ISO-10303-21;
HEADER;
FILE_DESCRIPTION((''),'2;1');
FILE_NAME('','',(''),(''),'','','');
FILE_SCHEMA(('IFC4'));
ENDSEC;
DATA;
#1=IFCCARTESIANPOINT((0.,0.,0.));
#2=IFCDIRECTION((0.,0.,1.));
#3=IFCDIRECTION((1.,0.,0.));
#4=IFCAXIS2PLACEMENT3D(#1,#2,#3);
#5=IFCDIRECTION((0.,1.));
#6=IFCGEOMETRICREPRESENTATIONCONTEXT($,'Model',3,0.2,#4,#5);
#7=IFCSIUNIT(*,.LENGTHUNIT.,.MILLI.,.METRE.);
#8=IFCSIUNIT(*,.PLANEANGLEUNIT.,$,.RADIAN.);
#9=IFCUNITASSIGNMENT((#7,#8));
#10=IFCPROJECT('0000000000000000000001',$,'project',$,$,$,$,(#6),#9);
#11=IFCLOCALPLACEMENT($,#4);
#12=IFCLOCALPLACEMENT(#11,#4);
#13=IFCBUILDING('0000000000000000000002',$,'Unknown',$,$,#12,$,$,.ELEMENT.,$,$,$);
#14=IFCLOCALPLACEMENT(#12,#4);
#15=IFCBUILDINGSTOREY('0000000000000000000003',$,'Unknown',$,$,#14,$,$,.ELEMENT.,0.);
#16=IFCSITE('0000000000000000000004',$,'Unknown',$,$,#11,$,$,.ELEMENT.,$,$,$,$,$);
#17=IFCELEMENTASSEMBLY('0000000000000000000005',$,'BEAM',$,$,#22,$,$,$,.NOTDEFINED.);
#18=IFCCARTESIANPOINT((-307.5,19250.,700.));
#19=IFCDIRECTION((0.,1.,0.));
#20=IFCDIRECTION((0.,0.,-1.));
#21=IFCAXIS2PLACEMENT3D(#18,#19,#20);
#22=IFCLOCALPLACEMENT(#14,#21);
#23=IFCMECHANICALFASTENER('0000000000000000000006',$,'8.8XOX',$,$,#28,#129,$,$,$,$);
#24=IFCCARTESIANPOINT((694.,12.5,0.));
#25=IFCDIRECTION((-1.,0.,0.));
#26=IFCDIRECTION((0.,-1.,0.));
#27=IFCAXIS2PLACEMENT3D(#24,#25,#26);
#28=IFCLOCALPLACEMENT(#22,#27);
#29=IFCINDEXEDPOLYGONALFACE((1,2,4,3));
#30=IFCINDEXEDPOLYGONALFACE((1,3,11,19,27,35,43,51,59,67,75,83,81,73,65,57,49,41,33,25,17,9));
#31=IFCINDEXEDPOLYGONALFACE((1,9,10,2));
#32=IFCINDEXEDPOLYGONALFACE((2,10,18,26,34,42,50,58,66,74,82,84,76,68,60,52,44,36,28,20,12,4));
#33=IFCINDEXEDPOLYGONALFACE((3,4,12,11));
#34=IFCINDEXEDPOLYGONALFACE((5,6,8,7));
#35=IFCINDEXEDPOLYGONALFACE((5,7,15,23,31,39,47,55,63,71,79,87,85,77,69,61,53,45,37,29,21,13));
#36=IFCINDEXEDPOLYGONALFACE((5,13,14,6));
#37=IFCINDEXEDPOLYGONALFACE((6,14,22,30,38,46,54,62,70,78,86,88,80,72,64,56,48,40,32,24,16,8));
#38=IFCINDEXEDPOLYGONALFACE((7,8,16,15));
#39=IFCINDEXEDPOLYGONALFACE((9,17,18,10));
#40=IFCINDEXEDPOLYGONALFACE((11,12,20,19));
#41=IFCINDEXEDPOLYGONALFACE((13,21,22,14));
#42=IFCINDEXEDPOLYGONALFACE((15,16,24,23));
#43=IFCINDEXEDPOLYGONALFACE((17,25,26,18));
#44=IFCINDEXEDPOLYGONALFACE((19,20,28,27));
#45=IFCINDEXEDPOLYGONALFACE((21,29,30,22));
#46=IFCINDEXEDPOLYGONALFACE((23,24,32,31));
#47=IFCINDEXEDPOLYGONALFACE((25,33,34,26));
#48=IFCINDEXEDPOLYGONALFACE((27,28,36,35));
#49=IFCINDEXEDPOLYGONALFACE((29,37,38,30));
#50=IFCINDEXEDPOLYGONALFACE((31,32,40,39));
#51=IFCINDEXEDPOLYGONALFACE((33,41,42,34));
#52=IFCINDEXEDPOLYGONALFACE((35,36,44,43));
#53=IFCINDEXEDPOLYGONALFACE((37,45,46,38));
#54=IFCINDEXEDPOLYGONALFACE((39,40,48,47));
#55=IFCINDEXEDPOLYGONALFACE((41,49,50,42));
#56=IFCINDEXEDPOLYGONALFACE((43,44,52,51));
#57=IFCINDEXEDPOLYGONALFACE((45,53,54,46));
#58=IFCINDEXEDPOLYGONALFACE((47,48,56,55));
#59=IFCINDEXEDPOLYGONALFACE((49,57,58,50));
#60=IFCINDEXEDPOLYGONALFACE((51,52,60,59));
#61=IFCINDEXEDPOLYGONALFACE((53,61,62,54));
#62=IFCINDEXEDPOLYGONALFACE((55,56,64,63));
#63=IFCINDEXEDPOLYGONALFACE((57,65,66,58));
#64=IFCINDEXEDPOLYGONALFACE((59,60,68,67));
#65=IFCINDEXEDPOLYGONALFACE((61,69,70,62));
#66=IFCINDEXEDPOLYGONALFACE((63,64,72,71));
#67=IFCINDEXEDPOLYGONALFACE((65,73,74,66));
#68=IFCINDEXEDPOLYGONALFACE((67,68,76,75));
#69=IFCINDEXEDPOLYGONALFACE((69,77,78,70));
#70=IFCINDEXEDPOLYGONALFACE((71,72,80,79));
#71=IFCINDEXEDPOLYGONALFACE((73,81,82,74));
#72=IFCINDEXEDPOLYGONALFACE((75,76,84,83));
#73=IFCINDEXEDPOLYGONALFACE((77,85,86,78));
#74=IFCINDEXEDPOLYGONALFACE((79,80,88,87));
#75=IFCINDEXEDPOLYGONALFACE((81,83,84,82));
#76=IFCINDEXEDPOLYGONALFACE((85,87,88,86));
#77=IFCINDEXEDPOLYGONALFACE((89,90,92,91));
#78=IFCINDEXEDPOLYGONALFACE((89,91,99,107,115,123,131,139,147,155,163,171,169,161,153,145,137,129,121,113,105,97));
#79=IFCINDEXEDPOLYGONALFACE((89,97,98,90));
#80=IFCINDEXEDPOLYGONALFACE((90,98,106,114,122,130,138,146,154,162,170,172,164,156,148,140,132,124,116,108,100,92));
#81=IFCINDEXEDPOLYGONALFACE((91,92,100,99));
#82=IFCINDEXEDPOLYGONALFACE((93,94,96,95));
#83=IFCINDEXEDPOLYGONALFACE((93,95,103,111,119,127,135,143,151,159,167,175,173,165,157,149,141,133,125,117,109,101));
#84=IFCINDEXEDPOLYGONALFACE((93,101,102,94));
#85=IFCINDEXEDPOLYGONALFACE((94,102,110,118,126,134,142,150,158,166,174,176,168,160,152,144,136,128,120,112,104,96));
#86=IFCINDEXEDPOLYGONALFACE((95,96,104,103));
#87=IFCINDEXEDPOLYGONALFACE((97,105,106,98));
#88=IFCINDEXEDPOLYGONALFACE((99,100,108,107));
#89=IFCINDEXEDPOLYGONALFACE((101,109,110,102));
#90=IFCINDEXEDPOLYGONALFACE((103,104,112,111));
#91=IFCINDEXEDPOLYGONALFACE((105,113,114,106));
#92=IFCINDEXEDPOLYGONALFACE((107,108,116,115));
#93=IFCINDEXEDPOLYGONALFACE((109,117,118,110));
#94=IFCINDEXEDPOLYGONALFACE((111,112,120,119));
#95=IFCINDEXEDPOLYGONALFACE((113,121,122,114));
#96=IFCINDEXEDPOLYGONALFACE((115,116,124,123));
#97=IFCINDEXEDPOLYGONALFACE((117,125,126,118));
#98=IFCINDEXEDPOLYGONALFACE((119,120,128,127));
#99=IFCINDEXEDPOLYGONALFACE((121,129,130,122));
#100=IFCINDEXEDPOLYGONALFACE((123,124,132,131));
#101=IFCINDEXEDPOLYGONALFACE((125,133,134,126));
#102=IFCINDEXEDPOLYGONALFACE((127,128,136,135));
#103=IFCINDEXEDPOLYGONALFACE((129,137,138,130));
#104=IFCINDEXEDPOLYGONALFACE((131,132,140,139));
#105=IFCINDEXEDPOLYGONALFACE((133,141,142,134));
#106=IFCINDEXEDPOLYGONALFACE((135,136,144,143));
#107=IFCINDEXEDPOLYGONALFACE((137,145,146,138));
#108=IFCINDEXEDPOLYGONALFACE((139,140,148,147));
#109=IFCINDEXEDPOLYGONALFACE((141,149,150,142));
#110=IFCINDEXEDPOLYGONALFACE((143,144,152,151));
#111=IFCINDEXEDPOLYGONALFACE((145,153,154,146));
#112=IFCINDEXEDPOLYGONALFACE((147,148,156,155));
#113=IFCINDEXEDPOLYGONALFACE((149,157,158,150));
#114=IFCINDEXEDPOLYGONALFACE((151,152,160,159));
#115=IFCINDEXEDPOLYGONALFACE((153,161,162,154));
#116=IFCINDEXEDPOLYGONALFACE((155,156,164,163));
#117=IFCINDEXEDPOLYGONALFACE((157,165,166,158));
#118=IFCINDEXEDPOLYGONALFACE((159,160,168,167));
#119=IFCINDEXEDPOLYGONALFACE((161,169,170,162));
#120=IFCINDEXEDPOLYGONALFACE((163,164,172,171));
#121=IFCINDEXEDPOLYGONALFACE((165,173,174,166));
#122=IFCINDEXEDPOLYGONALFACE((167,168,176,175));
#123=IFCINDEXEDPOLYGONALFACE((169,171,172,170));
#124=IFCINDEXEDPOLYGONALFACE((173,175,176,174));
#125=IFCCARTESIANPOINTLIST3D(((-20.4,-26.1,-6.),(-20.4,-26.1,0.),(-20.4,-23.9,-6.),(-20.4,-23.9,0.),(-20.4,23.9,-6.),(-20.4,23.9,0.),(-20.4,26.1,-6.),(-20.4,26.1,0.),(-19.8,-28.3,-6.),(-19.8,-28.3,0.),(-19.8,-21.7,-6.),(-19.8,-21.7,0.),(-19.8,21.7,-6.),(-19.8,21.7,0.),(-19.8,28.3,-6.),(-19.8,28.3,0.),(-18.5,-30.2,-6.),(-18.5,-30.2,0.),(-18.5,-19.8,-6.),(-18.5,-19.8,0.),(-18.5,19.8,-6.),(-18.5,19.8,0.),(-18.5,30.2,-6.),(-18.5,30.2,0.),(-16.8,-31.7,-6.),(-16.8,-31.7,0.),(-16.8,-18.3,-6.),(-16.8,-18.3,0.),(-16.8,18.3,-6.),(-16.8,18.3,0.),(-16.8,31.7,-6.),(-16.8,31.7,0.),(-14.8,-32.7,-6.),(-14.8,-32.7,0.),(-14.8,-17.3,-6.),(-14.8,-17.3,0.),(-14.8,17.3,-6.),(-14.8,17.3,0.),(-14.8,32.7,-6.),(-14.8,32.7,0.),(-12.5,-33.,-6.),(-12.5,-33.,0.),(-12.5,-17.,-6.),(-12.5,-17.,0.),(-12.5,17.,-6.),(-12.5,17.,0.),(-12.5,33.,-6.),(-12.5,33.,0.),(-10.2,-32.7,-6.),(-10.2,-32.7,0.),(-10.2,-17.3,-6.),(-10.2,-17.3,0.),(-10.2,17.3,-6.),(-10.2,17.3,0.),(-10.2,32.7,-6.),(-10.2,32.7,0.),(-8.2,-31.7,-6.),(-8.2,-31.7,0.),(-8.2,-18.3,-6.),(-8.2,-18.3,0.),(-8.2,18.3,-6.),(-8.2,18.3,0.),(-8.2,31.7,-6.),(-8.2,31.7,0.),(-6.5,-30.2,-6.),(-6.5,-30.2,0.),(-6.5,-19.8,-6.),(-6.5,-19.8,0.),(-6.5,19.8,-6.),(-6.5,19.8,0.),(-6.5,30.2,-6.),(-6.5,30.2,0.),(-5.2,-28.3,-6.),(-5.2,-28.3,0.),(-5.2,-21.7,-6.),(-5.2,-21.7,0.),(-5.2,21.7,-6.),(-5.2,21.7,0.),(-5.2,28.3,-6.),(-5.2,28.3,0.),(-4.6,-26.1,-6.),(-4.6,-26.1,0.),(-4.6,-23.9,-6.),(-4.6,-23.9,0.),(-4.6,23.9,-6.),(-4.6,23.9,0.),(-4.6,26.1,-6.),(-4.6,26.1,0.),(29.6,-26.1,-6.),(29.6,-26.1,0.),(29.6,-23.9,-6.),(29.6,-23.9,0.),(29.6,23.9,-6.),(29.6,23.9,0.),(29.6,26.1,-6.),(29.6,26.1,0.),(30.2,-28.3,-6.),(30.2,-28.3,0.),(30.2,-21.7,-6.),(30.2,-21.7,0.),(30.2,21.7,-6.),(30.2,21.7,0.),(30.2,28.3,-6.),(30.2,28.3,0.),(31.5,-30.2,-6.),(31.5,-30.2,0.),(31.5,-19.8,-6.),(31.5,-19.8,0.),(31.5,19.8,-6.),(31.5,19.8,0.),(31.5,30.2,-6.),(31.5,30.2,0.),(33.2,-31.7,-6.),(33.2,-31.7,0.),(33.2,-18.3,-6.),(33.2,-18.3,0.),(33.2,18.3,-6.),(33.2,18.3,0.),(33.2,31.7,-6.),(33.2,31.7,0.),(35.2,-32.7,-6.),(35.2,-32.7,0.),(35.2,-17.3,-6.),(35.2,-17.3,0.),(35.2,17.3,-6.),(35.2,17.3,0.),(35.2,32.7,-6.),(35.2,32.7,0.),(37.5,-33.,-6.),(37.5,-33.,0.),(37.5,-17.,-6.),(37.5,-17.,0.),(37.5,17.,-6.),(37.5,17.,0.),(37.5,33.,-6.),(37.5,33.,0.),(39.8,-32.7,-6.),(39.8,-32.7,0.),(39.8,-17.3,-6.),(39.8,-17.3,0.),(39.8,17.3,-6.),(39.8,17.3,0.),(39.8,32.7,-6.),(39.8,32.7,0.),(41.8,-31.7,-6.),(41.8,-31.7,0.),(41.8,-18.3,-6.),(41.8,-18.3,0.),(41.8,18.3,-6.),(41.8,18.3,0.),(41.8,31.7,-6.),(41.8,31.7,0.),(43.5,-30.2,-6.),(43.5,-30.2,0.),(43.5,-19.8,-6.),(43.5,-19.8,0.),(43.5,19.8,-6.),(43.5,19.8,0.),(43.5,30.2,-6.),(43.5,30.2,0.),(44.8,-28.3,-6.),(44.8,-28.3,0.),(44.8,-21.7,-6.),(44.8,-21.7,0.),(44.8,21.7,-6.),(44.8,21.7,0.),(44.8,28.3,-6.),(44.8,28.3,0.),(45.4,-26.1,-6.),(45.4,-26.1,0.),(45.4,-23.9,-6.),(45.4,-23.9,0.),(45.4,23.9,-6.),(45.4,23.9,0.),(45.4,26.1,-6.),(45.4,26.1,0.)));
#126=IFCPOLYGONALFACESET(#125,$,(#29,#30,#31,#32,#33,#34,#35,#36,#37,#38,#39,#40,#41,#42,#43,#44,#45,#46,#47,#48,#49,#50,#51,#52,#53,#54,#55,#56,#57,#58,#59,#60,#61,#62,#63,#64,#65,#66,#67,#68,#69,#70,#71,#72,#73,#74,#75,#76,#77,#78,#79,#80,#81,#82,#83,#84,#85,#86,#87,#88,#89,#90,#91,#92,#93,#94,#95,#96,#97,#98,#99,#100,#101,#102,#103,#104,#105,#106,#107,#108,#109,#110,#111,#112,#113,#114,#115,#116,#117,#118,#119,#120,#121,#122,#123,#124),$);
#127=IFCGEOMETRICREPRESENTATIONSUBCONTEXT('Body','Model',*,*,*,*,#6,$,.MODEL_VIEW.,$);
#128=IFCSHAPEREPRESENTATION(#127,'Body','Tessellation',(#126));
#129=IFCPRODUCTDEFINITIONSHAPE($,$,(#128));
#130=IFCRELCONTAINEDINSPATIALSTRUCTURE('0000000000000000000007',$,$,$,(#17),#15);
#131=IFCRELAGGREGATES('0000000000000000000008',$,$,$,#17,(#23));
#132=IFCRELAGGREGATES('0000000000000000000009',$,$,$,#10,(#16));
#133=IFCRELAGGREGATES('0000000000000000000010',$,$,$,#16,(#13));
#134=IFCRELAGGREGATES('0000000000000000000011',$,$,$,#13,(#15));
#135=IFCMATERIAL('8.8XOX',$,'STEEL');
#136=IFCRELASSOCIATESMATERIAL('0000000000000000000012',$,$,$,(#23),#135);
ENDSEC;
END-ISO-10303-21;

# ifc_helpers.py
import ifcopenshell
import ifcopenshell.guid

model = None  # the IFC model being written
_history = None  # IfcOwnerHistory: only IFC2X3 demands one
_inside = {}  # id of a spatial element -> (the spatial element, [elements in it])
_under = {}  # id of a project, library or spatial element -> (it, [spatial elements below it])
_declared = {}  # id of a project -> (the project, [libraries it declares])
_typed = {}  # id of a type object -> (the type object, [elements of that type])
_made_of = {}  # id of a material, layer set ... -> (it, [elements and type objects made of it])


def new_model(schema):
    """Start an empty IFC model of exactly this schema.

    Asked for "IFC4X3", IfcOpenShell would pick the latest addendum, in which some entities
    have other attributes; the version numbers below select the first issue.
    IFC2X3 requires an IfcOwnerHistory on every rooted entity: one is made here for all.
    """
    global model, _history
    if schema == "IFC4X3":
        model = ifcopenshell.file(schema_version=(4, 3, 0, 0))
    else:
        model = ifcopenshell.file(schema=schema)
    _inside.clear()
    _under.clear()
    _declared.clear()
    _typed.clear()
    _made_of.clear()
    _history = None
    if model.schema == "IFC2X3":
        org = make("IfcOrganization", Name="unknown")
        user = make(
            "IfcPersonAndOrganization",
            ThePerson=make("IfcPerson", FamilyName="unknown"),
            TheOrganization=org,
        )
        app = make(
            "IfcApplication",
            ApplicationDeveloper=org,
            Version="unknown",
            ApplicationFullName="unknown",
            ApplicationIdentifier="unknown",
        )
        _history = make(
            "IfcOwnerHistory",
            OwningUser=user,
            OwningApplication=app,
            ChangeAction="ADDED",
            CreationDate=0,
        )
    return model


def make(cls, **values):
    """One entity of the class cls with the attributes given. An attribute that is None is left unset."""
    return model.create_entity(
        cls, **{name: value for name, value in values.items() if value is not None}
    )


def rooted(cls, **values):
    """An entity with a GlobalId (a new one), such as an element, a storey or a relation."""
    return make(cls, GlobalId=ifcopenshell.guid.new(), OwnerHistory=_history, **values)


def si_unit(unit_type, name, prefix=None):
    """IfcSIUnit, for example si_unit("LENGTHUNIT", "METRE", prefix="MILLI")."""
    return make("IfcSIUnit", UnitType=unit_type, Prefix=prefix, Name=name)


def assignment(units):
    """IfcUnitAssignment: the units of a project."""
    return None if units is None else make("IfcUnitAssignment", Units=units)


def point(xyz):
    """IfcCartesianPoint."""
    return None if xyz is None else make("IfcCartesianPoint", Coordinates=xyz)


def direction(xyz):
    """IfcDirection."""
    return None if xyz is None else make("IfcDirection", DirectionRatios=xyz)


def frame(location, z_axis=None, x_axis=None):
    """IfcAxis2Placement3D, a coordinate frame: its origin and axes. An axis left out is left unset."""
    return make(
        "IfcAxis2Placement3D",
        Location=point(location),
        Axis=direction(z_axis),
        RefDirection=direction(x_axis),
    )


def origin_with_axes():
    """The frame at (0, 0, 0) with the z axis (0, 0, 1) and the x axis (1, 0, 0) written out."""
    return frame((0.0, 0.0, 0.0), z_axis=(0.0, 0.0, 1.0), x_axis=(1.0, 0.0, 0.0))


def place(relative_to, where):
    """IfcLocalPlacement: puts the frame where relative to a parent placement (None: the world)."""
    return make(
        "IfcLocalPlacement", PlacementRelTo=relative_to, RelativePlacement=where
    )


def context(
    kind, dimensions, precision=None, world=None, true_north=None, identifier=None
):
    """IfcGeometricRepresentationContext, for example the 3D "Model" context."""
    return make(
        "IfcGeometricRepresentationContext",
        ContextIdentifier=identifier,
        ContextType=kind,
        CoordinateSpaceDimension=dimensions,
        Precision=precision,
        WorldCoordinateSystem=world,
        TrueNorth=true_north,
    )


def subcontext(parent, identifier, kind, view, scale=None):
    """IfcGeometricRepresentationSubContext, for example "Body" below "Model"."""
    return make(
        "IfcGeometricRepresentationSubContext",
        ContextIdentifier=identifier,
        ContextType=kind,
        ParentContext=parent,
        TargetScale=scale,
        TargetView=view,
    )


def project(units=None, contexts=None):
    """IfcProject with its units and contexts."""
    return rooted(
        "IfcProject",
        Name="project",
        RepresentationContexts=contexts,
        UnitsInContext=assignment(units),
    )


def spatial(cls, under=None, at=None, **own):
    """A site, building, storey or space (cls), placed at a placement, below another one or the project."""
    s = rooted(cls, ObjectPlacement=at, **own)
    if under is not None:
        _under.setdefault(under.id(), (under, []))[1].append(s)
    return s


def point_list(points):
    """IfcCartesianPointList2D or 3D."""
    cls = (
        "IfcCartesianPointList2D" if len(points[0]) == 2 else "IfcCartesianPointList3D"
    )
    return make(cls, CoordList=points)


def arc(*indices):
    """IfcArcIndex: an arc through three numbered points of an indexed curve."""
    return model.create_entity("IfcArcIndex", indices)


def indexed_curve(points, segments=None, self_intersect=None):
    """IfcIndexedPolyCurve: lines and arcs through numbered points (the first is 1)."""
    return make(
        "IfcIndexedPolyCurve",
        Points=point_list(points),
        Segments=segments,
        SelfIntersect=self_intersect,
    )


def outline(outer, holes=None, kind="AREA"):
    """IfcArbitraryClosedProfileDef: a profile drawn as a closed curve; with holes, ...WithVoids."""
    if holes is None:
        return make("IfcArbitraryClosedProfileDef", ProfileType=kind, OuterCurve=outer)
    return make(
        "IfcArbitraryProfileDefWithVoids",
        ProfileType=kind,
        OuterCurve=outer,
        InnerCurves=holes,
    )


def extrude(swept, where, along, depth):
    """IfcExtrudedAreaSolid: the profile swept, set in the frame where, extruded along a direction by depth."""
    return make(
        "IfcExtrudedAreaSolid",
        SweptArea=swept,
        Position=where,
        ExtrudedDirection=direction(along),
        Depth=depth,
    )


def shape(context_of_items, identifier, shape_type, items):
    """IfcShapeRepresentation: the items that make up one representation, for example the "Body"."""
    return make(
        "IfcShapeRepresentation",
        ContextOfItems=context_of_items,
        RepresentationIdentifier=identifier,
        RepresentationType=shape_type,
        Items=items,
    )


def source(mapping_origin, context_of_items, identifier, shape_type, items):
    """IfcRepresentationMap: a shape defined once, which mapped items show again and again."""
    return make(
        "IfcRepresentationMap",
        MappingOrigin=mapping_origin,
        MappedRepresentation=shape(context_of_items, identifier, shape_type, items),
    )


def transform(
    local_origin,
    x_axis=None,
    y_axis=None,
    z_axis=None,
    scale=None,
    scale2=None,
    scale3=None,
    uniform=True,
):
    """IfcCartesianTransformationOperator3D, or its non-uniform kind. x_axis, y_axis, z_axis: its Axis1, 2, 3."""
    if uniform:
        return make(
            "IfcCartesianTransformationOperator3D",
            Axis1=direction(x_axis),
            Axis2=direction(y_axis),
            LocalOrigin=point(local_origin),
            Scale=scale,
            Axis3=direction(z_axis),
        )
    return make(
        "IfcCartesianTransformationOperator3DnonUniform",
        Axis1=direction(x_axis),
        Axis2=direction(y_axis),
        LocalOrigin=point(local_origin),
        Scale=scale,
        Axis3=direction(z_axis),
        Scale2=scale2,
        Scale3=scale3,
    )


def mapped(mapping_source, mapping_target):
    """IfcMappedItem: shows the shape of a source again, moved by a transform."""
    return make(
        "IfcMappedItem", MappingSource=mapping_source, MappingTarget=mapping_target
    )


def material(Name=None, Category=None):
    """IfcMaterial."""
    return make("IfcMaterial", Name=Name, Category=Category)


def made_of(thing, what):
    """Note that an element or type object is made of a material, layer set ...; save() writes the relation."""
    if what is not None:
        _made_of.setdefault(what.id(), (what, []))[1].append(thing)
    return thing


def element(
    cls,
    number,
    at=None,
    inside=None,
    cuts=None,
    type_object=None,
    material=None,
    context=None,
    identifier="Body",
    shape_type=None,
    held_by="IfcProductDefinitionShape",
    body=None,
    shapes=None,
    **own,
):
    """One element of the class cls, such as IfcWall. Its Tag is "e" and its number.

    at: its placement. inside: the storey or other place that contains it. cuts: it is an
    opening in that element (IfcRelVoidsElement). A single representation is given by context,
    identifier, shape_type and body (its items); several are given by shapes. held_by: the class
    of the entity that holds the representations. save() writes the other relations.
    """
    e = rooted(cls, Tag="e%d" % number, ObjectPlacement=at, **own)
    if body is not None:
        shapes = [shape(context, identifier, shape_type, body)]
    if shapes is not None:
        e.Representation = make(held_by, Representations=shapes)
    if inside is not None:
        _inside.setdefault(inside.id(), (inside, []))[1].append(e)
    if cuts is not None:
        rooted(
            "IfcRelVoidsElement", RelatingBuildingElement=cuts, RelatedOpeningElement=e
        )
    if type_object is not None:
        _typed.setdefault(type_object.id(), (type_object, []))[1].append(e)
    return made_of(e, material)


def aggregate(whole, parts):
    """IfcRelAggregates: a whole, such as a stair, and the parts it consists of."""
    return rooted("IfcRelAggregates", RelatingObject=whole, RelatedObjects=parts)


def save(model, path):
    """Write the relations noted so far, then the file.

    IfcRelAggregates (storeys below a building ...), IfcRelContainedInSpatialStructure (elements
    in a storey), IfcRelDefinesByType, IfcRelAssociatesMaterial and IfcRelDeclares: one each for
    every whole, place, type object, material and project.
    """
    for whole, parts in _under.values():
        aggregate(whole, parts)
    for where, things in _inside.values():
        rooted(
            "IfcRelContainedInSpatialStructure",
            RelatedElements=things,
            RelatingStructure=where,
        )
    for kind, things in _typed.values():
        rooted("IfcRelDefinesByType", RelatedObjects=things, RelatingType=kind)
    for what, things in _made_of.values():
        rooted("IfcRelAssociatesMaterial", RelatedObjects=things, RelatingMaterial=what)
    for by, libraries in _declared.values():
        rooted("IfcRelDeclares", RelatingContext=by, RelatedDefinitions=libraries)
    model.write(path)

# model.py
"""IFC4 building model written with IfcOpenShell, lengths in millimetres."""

from ifc_helpers import new_model, si_unit, direction, frame, origin_with_axes, place, context, subcontext, project, spatial, arc, indexed_curve, outline, extrude, source, transform, mapped, material, element, aggregate, save


model = new_model("IFC4")

# Units and contexts
model_context = context("Model", 3, precision=0.2, world=origin_with_axes(), true_north=direction((0.0, 1.0)))
body_context = subcontext(model_context, "Body", "Model", "MODEL_VIEW")
ifc_project = project(units=[si_unit("LENGTHUNIT", "METRE", prefix="MILLI"), si_unit("PLANEANGLEUNIT", "RADIAN")], contexts=[model_context])

# Site, building, storey
site_placement = place(None, origin_with_axes())
site = spatial("IfcSite", under=ifc_project, at=site_placement, Name="Unknown", CompositionType="ELEMENT")
building_placement = place(site_placement, origin_with_axes())
building = spatial("IfcBuilding", under=site, at=building_placement, Name="Unknown", CompositionType="ELEMENT")
storey_placement = place(building_placement, origin_with_axes())
storey = spatial("IfcBuildingStorey", under=building, at=storey_placement, Name="Unknown", CompositionType="ELEMENT", Elevation=0.0)

# Element assembly
assembly_1_placement = place(storey_placement, frame((-307.5, 19250.0, 700.0), z_axis=(0.0, 1.0, 0.0), x_axis=(0.0, 0.0, -1.0)))
assembly_1 = element("IfcElementAssembly", 1, at=assembly_1_placement, inside=storey, Name="BEAM", PredefinedType="NOTDEFINED")

# Shared definitions
ifc_material_1 = material(Name="8.8XOX", Category="STEEL")

# Mechanical fastener
shared_shape_1 = source(origin_with_axes(), body_context, "Body", "SweptSolid", [
    extrude(outline(indexed_curve([(8.0, 0.0), (0.0, 8.0), (-8.0, 0.0), (0.0, -8.0)], segments=[arc(1, 2, 3), arc(3, 4, 1)])), frame((0.0, 0.0, 0.0), z_axis=(0.0, 0.0, -1.0), x_axis=(0.0, 1.0, 0.0)), (0.0, 0.0, 1.0), 6.0),
])
mechanical_fastener_1_placement = place(assembly_1_placement, frame((694.0, 12.5, 0.0), z_axis=(-1.0, 0.0, 0.0), x_axis=(0.0, -1.0, 0.0)))
mechanical_fastener_1 = element("IfcMechanicalFastener", 2, at=mechanical_fastener_1_placement, material=ifc_material_1, Name="8.8XOX", context=body_context, shape_type="MappedRepresentation", body=[
    mapped(shared_shape_1, transform((-12.5, 25.0, 0.0))),
    mapped(shared_shape_1, transform((-12.5, -25.0, 0.0))),
    mapped(shared_shape_1, transform((37.5, 25.0, 0.0))),
    mapped(shared_shape_1, transform((37.5, -25.0, 0.0))),
])
aggregate(assembly_1, [mechanical_fastener_1])

save(model, "model.ifc")
